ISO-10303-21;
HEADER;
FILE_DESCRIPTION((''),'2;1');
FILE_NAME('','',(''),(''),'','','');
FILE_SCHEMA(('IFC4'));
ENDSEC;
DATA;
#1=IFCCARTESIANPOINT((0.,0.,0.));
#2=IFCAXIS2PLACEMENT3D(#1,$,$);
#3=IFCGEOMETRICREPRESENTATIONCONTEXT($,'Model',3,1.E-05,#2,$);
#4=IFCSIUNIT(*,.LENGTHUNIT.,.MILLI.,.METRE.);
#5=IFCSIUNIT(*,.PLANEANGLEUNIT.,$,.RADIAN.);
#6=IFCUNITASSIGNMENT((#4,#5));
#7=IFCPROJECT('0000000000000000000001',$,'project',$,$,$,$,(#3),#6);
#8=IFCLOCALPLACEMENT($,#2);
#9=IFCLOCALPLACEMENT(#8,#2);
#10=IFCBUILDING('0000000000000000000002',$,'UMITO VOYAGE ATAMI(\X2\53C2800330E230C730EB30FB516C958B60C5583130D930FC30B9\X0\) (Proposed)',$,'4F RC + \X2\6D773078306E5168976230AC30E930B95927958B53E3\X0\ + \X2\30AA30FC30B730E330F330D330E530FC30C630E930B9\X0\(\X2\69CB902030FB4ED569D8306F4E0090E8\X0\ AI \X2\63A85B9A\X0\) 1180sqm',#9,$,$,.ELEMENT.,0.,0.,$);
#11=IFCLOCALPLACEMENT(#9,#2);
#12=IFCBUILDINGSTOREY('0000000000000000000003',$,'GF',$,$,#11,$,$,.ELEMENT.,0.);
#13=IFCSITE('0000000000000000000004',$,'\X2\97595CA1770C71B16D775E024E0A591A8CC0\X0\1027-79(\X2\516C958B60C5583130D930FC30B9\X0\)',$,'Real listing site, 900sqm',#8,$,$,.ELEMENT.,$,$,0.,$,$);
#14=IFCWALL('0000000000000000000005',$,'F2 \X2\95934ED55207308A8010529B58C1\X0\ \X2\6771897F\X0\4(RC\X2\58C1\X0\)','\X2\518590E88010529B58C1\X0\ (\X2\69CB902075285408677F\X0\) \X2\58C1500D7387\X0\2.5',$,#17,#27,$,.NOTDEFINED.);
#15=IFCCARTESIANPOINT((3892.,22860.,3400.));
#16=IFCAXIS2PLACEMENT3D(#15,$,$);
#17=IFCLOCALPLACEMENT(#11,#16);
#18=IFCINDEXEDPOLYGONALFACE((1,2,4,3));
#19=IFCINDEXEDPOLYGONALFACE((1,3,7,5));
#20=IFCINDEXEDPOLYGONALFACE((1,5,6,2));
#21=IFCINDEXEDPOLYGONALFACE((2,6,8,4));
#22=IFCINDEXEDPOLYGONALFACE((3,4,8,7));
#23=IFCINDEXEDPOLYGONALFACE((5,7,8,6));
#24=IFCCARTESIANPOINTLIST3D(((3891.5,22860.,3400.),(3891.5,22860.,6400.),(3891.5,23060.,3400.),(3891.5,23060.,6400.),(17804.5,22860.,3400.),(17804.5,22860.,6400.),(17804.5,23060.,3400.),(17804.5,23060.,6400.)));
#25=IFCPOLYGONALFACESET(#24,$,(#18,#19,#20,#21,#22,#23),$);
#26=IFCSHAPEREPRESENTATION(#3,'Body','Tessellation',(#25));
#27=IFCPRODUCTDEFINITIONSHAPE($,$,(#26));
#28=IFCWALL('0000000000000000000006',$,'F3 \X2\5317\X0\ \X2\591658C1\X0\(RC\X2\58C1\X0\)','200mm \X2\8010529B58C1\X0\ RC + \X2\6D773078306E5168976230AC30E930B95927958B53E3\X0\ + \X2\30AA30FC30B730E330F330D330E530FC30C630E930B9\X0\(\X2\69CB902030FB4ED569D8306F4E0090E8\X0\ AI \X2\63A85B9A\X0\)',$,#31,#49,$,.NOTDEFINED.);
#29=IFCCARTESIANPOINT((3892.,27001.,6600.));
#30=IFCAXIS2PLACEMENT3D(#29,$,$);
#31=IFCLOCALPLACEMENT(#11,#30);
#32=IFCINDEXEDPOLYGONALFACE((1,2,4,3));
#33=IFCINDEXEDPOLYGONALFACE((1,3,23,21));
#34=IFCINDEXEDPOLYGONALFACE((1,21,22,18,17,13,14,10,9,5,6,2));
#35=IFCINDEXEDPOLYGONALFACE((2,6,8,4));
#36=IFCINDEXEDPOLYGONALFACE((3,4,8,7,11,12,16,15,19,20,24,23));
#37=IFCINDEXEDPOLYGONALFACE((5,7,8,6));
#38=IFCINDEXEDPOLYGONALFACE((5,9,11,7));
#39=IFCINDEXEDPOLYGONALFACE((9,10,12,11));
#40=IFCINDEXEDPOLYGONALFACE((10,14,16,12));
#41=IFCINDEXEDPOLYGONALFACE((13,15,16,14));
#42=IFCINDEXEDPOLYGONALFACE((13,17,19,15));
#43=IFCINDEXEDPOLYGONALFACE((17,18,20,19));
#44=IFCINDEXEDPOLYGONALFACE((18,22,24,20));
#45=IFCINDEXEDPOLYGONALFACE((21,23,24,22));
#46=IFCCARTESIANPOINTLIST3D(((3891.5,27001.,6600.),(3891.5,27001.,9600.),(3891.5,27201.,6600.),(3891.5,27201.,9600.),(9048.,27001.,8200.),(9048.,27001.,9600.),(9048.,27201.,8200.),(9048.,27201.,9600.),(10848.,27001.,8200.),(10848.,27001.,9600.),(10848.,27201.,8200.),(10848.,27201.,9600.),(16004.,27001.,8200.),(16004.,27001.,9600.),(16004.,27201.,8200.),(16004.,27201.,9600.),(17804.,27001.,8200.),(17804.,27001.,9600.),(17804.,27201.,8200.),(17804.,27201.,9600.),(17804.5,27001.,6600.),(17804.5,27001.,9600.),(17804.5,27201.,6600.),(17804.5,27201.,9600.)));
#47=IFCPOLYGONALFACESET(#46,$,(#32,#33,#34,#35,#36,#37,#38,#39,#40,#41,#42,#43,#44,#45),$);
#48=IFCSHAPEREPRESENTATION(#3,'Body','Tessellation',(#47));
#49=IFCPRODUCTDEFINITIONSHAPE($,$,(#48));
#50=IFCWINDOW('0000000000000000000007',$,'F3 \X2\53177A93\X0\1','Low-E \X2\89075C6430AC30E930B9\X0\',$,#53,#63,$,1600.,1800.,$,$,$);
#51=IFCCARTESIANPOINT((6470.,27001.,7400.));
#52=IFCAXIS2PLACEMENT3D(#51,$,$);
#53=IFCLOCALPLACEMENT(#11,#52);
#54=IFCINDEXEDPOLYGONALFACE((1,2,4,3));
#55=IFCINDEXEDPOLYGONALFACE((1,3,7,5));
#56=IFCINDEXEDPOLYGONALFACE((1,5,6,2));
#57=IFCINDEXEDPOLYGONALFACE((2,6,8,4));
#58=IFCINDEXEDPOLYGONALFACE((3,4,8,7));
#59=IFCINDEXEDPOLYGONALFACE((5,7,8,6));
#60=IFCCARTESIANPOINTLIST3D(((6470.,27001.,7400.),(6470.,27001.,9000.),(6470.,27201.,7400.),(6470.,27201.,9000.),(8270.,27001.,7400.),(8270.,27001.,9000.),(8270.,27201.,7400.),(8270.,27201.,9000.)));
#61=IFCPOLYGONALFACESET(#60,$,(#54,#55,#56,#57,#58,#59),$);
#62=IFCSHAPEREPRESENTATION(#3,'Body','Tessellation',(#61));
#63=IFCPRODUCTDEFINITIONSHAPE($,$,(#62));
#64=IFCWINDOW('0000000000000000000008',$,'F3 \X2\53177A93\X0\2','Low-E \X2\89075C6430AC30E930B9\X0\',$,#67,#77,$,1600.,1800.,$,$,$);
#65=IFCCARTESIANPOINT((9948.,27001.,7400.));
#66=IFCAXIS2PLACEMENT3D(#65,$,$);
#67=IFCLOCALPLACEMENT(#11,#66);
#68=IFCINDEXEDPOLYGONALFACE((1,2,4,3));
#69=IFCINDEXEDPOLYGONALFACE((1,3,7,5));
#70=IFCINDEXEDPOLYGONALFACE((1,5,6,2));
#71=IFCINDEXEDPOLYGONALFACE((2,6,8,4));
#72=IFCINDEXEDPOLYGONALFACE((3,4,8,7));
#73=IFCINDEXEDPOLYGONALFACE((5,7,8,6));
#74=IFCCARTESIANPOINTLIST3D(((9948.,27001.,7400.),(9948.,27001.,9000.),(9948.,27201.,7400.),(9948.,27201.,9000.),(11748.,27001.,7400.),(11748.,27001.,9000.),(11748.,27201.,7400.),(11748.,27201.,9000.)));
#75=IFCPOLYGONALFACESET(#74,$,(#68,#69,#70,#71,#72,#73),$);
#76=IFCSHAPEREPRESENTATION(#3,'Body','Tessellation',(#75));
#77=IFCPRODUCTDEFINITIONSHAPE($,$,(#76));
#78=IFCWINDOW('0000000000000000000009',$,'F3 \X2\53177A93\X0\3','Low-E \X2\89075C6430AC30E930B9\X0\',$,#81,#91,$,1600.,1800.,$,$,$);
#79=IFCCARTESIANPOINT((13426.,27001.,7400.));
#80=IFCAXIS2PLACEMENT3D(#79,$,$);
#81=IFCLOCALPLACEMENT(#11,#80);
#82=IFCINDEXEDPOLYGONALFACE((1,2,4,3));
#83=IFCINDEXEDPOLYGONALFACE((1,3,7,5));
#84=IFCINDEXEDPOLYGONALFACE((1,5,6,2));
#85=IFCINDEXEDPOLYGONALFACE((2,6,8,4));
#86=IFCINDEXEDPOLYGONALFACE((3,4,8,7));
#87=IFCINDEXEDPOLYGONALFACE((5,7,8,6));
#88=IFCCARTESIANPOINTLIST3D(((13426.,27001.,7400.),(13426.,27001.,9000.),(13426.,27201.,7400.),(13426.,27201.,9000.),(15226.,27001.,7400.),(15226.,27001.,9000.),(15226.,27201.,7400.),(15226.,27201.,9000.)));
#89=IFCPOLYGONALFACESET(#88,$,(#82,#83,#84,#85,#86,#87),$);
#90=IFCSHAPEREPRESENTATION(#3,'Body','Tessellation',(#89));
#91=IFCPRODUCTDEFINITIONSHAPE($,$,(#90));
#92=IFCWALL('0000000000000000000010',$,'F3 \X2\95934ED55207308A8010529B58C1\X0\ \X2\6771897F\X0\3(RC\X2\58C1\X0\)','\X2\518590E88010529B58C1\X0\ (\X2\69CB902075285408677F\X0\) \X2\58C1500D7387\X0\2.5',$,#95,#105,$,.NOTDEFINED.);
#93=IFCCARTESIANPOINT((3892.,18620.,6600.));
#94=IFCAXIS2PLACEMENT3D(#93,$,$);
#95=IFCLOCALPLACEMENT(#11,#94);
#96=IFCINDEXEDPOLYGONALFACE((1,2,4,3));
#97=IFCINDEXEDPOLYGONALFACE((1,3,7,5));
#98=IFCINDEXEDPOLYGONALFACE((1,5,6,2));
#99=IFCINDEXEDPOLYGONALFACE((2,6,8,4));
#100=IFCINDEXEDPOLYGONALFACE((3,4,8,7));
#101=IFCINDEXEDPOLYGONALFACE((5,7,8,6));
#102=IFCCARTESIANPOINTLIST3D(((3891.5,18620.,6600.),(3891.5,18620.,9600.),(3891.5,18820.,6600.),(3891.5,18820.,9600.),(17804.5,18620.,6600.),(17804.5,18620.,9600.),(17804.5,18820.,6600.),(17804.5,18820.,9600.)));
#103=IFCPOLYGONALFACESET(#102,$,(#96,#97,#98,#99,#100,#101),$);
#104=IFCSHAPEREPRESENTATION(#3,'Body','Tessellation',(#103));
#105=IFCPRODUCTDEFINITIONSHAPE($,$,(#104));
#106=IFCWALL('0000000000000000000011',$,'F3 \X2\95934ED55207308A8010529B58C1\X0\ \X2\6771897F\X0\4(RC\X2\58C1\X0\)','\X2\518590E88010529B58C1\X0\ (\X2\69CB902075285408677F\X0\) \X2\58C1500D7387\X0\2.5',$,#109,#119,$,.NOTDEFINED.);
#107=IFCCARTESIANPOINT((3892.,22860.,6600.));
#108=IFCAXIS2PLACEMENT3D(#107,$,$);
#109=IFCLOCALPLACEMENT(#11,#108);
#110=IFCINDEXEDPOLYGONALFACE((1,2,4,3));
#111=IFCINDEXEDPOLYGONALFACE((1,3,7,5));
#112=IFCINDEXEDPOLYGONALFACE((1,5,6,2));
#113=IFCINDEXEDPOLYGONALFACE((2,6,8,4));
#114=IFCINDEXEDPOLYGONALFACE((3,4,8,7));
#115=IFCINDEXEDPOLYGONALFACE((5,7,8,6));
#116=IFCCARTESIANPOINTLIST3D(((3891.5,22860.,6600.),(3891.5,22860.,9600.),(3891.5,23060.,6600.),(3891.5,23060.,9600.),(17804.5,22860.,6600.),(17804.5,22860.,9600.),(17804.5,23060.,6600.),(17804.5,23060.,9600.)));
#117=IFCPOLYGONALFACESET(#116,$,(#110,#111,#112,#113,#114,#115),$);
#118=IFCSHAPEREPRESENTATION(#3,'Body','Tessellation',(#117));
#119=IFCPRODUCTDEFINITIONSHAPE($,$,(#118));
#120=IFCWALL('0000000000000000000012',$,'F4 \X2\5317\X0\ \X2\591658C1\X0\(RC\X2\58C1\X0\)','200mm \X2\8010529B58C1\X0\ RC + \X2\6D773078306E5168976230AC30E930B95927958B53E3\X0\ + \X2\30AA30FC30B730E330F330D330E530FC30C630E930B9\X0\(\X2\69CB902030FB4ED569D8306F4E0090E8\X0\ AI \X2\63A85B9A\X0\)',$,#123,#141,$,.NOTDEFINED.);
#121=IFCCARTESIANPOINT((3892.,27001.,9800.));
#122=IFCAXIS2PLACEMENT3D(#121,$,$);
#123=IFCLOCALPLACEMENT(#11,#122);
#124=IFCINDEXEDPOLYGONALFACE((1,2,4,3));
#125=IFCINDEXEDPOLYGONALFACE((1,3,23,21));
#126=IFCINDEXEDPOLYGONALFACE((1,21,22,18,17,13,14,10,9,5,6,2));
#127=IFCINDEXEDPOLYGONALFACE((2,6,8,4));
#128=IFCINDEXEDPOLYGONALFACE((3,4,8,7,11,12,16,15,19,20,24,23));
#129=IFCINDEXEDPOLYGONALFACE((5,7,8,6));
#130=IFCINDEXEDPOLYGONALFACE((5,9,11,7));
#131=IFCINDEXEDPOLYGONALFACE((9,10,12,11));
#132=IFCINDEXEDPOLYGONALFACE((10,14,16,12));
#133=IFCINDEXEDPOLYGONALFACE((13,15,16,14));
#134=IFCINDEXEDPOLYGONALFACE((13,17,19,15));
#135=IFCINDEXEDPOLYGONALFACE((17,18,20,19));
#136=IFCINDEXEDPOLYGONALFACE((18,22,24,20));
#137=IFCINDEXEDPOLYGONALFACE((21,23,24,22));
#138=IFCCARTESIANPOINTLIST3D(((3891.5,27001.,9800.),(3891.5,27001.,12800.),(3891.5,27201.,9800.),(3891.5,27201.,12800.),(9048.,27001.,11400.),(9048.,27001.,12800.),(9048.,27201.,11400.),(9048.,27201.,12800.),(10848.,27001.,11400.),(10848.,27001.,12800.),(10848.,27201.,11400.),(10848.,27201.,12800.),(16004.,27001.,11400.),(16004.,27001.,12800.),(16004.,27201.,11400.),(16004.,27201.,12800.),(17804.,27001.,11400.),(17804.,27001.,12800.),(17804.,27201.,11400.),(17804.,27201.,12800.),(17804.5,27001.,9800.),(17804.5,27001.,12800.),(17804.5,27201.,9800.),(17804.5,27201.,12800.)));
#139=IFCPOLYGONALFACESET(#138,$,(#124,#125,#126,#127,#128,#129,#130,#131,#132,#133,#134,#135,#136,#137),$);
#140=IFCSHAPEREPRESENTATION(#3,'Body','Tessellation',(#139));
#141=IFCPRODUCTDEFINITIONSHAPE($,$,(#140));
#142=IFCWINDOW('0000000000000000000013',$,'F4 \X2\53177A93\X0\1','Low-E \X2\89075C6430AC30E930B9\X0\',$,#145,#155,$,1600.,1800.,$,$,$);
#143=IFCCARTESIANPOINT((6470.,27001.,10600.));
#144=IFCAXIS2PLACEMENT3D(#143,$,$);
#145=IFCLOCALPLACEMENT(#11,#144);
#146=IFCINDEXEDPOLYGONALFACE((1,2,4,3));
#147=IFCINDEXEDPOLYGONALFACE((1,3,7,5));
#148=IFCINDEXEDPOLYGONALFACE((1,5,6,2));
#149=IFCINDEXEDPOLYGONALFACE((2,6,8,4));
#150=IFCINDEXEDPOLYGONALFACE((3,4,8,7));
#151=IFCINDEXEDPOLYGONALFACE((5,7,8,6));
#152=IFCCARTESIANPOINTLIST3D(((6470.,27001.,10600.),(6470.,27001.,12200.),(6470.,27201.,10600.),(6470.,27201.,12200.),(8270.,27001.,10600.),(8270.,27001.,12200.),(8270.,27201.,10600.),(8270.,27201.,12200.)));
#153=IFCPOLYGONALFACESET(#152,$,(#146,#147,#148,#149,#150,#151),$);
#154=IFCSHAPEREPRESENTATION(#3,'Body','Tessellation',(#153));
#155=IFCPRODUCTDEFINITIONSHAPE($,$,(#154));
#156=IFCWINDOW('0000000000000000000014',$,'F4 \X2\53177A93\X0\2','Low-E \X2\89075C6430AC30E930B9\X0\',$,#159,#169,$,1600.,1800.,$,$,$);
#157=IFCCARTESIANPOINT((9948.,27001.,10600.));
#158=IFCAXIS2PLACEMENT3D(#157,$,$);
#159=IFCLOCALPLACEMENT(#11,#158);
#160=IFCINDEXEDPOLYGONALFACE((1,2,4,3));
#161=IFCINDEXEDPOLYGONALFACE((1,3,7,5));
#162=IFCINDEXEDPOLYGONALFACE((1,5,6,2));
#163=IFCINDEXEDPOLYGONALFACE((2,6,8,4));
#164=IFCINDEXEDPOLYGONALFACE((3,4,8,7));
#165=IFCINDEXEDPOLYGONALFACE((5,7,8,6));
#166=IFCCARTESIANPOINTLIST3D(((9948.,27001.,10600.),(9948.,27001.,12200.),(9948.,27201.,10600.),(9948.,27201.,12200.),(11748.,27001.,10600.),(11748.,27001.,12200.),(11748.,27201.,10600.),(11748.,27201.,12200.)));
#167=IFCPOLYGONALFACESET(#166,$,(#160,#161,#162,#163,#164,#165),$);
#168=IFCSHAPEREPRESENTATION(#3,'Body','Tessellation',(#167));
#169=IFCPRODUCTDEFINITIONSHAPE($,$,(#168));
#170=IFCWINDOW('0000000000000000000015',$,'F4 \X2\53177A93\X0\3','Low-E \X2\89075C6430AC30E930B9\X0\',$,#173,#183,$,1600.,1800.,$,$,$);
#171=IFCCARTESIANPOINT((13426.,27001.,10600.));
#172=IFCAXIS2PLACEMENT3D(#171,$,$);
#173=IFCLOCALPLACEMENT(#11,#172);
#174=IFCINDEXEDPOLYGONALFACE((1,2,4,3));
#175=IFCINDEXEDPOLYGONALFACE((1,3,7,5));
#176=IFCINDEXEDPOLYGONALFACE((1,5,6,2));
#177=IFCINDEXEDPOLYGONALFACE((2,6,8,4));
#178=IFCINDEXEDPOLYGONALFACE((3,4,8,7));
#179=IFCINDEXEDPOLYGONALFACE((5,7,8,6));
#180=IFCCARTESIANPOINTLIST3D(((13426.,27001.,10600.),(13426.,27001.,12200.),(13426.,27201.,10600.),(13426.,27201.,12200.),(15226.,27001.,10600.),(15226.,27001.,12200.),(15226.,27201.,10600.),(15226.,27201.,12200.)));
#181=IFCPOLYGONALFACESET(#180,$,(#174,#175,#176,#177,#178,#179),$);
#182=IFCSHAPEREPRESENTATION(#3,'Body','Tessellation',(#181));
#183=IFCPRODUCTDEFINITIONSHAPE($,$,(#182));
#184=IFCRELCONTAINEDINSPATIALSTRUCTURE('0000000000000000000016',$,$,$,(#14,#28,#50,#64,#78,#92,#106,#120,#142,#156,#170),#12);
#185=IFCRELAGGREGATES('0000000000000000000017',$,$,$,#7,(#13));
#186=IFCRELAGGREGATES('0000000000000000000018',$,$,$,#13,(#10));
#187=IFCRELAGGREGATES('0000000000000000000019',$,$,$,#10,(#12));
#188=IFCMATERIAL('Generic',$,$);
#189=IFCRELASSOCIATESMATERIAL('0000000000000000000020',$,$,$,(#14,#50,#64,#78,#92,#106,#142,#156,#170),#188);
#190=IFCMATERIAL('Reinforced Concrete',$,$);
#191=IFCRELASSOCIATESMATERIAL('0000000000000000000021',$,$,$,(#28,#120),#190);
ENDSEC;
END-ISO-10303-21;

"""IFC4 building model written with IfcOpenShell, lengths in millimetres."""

from ifc_helpers import new_model, si_unit, frame, frame_2d, origin, place, context, project, spatial, rectangle, extrude, material, element, fill, save


model = new_model("IFC4")

# Units and contexts
model_context = context("Model", 3, precision=1e-05, world=origin())
ifc_project = project(units=[si_unit("LENGTHUNIT", "METRE", prefix="MILLI"), si_unit("PLANEANGLEUNIT", "RADIAN")], contexts=[model_context])

# Site, building, storey
site_placement = place(None, origin())
site = spatial("IfcSite", under=ifc_project, at=site_placement, Name="静岡県熱海市上多賀1027-79(公開情報ベース)", ObjectType="Real listing site, 900sqm", CompositionType="ELEMENT", RefElevation=0.0)
building_placement = place(site_placement, origin())
building = spatial("IfcBuilding", under=site, at=building_placement, Name="UMITO VOYAGE ATAMI(参考モデル・公開情報ベース) (Proposed)", ObjectType="4F RC + 海への全面ガラス大開口 + オーシャンビューテラス(構造・仕様は一部 AI 推定) 1180sqm", CompositionType="ELEMENT", ElevationOfRefHeight=0.0, ElevationOfTerrain=0.0)
storey_placement = place(building_placement, origin())
storey = spatial("IfcBuildingStorey", under=building, at=storey_placement, Name="GF", CompositionType="ELEMENT", Elevation=0.0)

# Shared definitions
ifc_material_1 = material(Name="Reinforced Concrete")
ifc_material_2 = material(Name="Generic")

# Wall
wall_1_placement = place(storey_placement, frame((3892.0, 22860.0, 3400.0)))
element("IfcWall", 1, at=wall_1_placement, inside=storey, material=ifc_material_2, Name="F2 間仕切り耐力壁 東西4(RC壁)", Description="内部耐力壁 (構造用合板) 壁倍率2.5", PredefinedType="NOTDEFINED", context=model_context, shape_type="SweptSolid", body=[
    extrude(rectangle(XDim=13913.0, YDim=200.0, at=frame_2d((6956.0, 100.0))), frame((3892.0, 22860.0, 3400.0)), (0.0, 0.0, 1.0), 3000.0),
])

# Wall, openings, windows
wall_2_placement = place(storey_placement, frame((3892.0, 27001.0, 6600.0)))
wall_2 = element("IfcWall", 2, at=wall_2_placement, inside=storey, material=ifc_material_1, Name="F3 北 外壁(RC壁)", Description="200mm 耐力壁 RC + 海への全面ガラス大開口 + オーシャンビューテラス(構造・仕様は一部 AI 推定)", PredefinedType="NOTDEFINED", context=model_context, shape_type="SweptSolid", body=[
    extrude(rectangle(XDim=13913.0, YDim=200.0, at=frame_2d((6956.0, 100.0))), frame((3892.0, 27001.0, 6600.0)), (0.0, 0.0, 1.0), 3000.0),
])
opening_1_placement = place(storey_placement, frame((6470.0, 27001.0, 7400.0)))
opening_1 = element("IfcOpeningElement", 3, at=opening_1_placement, cuts=wall_2, PredefinedType="NOTDEFINED", context=model_context, shape_type="SweptSolid", body=[
    extrude(rectangle(XDim=1800.0, YDim=200.0, at=frame_2d((900.0, 100.0))), frame((6470.0, 27001.0, 7400.0)), (0.0, 0.0, 1.0), 1600.0),
])
opening_2_placement = place(storey_placement, frame((9948.0, 27001.0, 7400.0)))
opening_2 = element("IfcOpeningElement", 4, at=opening_2_placement, cuts=wall_2, PredefinedType="NOTDEFINED", context=model_context, shape_type="SweptSolid", body=[
    extrude(rectangle(XDim=1800.0, YDim=200.0, at=frame_2d((900.0, 100.0))), frame((9948.0, 27001.0, 7400.0)), (0.0, 0.0, 1.0), 1600.0),
])
opening_3_placement = place(storey_placement, frame((13426.0, 27001.0, 7400.0)))
opening_3 = element("IfcOpeningElement", 5, at=opening_3_placement, cuts=wall_2, PredefinedType="NOTDEFINED", context=model_context, shape_type="SweptSolid", body=[
    extrude(rectangle(XDim=1800.0, YDim=200.0, at=frame_2d((900.0, 100.0))), frame((13426.0, 27001.0, 7400.0)), (0.0, 0.0, 1.0), 1600.0),
])
window_1_placement = place(storey_placement, frame((6470.0, 27001.0, 7400.0)))
window_1 = element("IfcWindow", 6, at=window_1_placement, inside=storey, material=ifc_material_2, Name="F3 北窓1", Description="Low-E 複層ガラス", OverallHeight=1600.0, OverallWidth=1800.0, context=model_context, shape_type="SweptSolid", body=[
    extrude(rectangle(XDim=1800.0, YDim=200.0, at=frame_2d((900.0, 100.0))), frame((6470.0, 27001.0, 7400.0)), (0.0, 0.0, 1.0), 1600.0),
])
fill(opening_1, window_1)
window_2_placement = place(storey_placement, frame((9948.0, 27001.0, 7400.0)))
window_2 = element("IfcWindow", 7, at=window_2_placement, inside=storey, material=ifc_material_2, Name="F3 北窓2", Description="Low-E 複層ガラス", OverallHeight=1600.0, OverallWidth=1800.0, context=model_context, shape_type="SweptSolid", body=[
    extrude(rectangle(XDim=1800.0, YDim=200.0, at=frame_2d((900.0, 100.0))), frame((9948.0, 27001.0, 7400.0)), (0.0, 0.0, 1.0), 1600.0),
])
fill(opening_2, window_2)
window_3_placement = place(storey_placement, frame((13426.0, 27001.0, 7400.0)))
window_3 = element("IfcWindow", 8, at=window_3_placement, inside=storey, material=ifc_material_2, Name="F3 北窓3", Description="Low-E 複層ガラス", OverallHeight=1600.0, OverallWidth=1800.0, context=model_context, shape_type="SweptSolid", body=[
    extrude(rectangle(XDim=1800.0, YDim=200.0, at=frame_2d((900.0, 100.0))), frame((13426.0, 27001.0, 7400.0)), (0.0, 0.0, 1.0), 1600.0),
])
fill(opening_3, window_3)

# Walls
wall_3_placement = place(storey_placement, frame((3892.0, 18620.0, 6600.0)))
element("IfcWall", 9, at=wall_3_placement, inside=storey, material=ifc_material_2, Name="F3 間仕切り耐力壁 東西3(RC壁)", Description="内部耐力壁 (構造用合板) 壁倍率2.5", PredefinedType="NOTDEFINED", context=model_context, shape_type="SweptSolid", body=[
    extrude(rectangle(XDim=13913.0, YDim=200.0, at=frame_2d((6956.0, 100.0))), frame((3892.0, 18620.0, 6600.0)), (0.0, 0.0, 1.0), 3000.0),
])
wall_4_placement = place(storey_placement, frame((3892.0, 22860.0, 6600.0)))
element("IfcWall", 10, at=wall_4_placement, inside=storey, material=ifc_material_2, Name="F3 間仕切り耐力壁 東西4(RC壁)", Description="内部耐力壁 (構造用合板) 壁倍率2.5", PredefinedType="NOTDEFINED", context=model_context, shape_type="SweptSolid", body=[
    extrude(rectangle(XDim=13913.0, YDim=200.0, at=frame_2d((6956.0, 100.0))), frame((3892.0, 22860.0, 6600.0)), (0.0, 0.0, 1.0), 3000.0),
])

# Wall, openings, windows
wall_5_placement = place(storey_placement, frame((3892.0, 27001.0, 9800.0)))
wall_5 = element("IfcWall", 11, at=wall_5_placement, inside=storey, material=ifc_material_1, Name="F4 北 外壁(RC壁)", Description="200mm 耐力壁 RC + 海への全面ガラス大開口 + オーシャンビューテラス(構造・仕様は一部 AI 推定)", PredefinedType="NOTDEFINED", context=model_context, shape_type="SweptSolid", body=[
    extrude(rectangle(XDim=13913.0, YDim=200.0, at=frame_2d((6956.0, 100.0))), frame((3892.0, 27001.0, 9800.0)), (0.0, 0.0, 1.0), 3000.0),
])
opening_4_placement = place(storey_placement, frame((6470.0, 27001.0, 10600.0)))
opening_4 = element("IfcOpeningElement", 12, at=opening_4_placement, cuts=wall_5, PredefinedType="NOTDEFINED", context=model_context, shape_type="SweptSolid", body=[
    extrude(rectangle(XDim=1800.0, YDim=200.0, at=frame_2d((900.0, 100.0))), frame((6470.0, 27001.0, 10600.0)), (0.0, 0.0, 1.0), 1600.0),
])
opening_5_placement = place(storey_placement, frame((9948.0, 27001.0, 10600.0)))
opening_5 = element("IfcOpeningElement", 13, at=opening_5_placement, cuts=wall_5, PredefinedType="NOTDEFINED", context=model_context, shape_type="SweptSolid", body=[
    extrude(rectangle(XDim=1800.0, YDim=200.0, at=frame_2d((900.0, 100.0))), frame((9948.0, 27001.0, 10600.0)), (0.0, 0.0, 1.0), 1600.0),
])
opening_6_placement = place(storey_placement, frame((13426.0, 27001.0, 10600.0)))
opening_6 = element("IfcOpeningElement", 14, at=opening_6_placement, cuts=wall_5, PredefinedType="NOTDEFINED", context=model_context, shape_type="SweptSolid", body=[
    extrude(rectangle(XDim=1800.0, YDim=200.0, at=frame_2d((900.0, 100.0))), frame((13426.0, 27001.0, 10600.0)), (0.0, 0.0, 1.0), 1600.0),
])
window_4_placement = place(storey_placement, frame((6470.0, 27001.0, 10600.0)))
window_4 = element("IfcWindow", 15, at=window_4_placement, inside=storey, material=ifc_material_2, Name="F4 北窓1", Description="Low-E 複層ガラス", OverallHeight=1600.0, OverallWidth=1800.0, context=model_context, shape_type="SweptSolid", body=[
    extrude(rectangle(XDim=1800.0, YDim=200.0, at=frame_2d((900.0, 100.0))), frame((6470.0, 27001.0, 10600.0)), (0.0, 0.0, 1.0), 1600.0),
])
fill(opening_4, window_4)
window_5_placement = place(storey_placement, frame((9948.0, 27001.0, 10600.0)))
window_5 = element("IfcWindow", 16, at=window_5_placement, inside=storey, material=ifc_material_2, Name="F4 北窓2", Description="Low-E 複層ガラス", OverallHeight=1600.0, OverallWidth=1800.0, context=model_context, shape_type="SweptSolid", body=[
    extrude(rectangle(XDim=1800.0, YDim=200.0, at=frame_2d((900.0, 100.0))), frame((9948.0, 27001.0, 10600.0)), (0.0, 0.0, 1.0), 1600.0),
])
fill(opening_5, window_5)
window_6_placement = place(storey_placement, frame((13426.0, 27001.0, 10600.0)))
window_6 = element("IfcWindow", 17, at=window_6_placement, inside=storey, material=ifc_material_2, Name="F4 北窓3", Description="Low-E 複層ガラス", OverallHeight=1600.0, OverallWidth=1800.0, context=model_context, shape_type="SweptSolid", body=[
    extrude(rectangle(XDim=1800.0, YDim=200.0, at=frame_2d((900.0, 100.0))), frame((13426.0, 27001.0, 10600.0)), (0.0, 0.0, 1.0), 1600.0),
])
fill(opening_6, window_6)

save(model, "model.ifc")
